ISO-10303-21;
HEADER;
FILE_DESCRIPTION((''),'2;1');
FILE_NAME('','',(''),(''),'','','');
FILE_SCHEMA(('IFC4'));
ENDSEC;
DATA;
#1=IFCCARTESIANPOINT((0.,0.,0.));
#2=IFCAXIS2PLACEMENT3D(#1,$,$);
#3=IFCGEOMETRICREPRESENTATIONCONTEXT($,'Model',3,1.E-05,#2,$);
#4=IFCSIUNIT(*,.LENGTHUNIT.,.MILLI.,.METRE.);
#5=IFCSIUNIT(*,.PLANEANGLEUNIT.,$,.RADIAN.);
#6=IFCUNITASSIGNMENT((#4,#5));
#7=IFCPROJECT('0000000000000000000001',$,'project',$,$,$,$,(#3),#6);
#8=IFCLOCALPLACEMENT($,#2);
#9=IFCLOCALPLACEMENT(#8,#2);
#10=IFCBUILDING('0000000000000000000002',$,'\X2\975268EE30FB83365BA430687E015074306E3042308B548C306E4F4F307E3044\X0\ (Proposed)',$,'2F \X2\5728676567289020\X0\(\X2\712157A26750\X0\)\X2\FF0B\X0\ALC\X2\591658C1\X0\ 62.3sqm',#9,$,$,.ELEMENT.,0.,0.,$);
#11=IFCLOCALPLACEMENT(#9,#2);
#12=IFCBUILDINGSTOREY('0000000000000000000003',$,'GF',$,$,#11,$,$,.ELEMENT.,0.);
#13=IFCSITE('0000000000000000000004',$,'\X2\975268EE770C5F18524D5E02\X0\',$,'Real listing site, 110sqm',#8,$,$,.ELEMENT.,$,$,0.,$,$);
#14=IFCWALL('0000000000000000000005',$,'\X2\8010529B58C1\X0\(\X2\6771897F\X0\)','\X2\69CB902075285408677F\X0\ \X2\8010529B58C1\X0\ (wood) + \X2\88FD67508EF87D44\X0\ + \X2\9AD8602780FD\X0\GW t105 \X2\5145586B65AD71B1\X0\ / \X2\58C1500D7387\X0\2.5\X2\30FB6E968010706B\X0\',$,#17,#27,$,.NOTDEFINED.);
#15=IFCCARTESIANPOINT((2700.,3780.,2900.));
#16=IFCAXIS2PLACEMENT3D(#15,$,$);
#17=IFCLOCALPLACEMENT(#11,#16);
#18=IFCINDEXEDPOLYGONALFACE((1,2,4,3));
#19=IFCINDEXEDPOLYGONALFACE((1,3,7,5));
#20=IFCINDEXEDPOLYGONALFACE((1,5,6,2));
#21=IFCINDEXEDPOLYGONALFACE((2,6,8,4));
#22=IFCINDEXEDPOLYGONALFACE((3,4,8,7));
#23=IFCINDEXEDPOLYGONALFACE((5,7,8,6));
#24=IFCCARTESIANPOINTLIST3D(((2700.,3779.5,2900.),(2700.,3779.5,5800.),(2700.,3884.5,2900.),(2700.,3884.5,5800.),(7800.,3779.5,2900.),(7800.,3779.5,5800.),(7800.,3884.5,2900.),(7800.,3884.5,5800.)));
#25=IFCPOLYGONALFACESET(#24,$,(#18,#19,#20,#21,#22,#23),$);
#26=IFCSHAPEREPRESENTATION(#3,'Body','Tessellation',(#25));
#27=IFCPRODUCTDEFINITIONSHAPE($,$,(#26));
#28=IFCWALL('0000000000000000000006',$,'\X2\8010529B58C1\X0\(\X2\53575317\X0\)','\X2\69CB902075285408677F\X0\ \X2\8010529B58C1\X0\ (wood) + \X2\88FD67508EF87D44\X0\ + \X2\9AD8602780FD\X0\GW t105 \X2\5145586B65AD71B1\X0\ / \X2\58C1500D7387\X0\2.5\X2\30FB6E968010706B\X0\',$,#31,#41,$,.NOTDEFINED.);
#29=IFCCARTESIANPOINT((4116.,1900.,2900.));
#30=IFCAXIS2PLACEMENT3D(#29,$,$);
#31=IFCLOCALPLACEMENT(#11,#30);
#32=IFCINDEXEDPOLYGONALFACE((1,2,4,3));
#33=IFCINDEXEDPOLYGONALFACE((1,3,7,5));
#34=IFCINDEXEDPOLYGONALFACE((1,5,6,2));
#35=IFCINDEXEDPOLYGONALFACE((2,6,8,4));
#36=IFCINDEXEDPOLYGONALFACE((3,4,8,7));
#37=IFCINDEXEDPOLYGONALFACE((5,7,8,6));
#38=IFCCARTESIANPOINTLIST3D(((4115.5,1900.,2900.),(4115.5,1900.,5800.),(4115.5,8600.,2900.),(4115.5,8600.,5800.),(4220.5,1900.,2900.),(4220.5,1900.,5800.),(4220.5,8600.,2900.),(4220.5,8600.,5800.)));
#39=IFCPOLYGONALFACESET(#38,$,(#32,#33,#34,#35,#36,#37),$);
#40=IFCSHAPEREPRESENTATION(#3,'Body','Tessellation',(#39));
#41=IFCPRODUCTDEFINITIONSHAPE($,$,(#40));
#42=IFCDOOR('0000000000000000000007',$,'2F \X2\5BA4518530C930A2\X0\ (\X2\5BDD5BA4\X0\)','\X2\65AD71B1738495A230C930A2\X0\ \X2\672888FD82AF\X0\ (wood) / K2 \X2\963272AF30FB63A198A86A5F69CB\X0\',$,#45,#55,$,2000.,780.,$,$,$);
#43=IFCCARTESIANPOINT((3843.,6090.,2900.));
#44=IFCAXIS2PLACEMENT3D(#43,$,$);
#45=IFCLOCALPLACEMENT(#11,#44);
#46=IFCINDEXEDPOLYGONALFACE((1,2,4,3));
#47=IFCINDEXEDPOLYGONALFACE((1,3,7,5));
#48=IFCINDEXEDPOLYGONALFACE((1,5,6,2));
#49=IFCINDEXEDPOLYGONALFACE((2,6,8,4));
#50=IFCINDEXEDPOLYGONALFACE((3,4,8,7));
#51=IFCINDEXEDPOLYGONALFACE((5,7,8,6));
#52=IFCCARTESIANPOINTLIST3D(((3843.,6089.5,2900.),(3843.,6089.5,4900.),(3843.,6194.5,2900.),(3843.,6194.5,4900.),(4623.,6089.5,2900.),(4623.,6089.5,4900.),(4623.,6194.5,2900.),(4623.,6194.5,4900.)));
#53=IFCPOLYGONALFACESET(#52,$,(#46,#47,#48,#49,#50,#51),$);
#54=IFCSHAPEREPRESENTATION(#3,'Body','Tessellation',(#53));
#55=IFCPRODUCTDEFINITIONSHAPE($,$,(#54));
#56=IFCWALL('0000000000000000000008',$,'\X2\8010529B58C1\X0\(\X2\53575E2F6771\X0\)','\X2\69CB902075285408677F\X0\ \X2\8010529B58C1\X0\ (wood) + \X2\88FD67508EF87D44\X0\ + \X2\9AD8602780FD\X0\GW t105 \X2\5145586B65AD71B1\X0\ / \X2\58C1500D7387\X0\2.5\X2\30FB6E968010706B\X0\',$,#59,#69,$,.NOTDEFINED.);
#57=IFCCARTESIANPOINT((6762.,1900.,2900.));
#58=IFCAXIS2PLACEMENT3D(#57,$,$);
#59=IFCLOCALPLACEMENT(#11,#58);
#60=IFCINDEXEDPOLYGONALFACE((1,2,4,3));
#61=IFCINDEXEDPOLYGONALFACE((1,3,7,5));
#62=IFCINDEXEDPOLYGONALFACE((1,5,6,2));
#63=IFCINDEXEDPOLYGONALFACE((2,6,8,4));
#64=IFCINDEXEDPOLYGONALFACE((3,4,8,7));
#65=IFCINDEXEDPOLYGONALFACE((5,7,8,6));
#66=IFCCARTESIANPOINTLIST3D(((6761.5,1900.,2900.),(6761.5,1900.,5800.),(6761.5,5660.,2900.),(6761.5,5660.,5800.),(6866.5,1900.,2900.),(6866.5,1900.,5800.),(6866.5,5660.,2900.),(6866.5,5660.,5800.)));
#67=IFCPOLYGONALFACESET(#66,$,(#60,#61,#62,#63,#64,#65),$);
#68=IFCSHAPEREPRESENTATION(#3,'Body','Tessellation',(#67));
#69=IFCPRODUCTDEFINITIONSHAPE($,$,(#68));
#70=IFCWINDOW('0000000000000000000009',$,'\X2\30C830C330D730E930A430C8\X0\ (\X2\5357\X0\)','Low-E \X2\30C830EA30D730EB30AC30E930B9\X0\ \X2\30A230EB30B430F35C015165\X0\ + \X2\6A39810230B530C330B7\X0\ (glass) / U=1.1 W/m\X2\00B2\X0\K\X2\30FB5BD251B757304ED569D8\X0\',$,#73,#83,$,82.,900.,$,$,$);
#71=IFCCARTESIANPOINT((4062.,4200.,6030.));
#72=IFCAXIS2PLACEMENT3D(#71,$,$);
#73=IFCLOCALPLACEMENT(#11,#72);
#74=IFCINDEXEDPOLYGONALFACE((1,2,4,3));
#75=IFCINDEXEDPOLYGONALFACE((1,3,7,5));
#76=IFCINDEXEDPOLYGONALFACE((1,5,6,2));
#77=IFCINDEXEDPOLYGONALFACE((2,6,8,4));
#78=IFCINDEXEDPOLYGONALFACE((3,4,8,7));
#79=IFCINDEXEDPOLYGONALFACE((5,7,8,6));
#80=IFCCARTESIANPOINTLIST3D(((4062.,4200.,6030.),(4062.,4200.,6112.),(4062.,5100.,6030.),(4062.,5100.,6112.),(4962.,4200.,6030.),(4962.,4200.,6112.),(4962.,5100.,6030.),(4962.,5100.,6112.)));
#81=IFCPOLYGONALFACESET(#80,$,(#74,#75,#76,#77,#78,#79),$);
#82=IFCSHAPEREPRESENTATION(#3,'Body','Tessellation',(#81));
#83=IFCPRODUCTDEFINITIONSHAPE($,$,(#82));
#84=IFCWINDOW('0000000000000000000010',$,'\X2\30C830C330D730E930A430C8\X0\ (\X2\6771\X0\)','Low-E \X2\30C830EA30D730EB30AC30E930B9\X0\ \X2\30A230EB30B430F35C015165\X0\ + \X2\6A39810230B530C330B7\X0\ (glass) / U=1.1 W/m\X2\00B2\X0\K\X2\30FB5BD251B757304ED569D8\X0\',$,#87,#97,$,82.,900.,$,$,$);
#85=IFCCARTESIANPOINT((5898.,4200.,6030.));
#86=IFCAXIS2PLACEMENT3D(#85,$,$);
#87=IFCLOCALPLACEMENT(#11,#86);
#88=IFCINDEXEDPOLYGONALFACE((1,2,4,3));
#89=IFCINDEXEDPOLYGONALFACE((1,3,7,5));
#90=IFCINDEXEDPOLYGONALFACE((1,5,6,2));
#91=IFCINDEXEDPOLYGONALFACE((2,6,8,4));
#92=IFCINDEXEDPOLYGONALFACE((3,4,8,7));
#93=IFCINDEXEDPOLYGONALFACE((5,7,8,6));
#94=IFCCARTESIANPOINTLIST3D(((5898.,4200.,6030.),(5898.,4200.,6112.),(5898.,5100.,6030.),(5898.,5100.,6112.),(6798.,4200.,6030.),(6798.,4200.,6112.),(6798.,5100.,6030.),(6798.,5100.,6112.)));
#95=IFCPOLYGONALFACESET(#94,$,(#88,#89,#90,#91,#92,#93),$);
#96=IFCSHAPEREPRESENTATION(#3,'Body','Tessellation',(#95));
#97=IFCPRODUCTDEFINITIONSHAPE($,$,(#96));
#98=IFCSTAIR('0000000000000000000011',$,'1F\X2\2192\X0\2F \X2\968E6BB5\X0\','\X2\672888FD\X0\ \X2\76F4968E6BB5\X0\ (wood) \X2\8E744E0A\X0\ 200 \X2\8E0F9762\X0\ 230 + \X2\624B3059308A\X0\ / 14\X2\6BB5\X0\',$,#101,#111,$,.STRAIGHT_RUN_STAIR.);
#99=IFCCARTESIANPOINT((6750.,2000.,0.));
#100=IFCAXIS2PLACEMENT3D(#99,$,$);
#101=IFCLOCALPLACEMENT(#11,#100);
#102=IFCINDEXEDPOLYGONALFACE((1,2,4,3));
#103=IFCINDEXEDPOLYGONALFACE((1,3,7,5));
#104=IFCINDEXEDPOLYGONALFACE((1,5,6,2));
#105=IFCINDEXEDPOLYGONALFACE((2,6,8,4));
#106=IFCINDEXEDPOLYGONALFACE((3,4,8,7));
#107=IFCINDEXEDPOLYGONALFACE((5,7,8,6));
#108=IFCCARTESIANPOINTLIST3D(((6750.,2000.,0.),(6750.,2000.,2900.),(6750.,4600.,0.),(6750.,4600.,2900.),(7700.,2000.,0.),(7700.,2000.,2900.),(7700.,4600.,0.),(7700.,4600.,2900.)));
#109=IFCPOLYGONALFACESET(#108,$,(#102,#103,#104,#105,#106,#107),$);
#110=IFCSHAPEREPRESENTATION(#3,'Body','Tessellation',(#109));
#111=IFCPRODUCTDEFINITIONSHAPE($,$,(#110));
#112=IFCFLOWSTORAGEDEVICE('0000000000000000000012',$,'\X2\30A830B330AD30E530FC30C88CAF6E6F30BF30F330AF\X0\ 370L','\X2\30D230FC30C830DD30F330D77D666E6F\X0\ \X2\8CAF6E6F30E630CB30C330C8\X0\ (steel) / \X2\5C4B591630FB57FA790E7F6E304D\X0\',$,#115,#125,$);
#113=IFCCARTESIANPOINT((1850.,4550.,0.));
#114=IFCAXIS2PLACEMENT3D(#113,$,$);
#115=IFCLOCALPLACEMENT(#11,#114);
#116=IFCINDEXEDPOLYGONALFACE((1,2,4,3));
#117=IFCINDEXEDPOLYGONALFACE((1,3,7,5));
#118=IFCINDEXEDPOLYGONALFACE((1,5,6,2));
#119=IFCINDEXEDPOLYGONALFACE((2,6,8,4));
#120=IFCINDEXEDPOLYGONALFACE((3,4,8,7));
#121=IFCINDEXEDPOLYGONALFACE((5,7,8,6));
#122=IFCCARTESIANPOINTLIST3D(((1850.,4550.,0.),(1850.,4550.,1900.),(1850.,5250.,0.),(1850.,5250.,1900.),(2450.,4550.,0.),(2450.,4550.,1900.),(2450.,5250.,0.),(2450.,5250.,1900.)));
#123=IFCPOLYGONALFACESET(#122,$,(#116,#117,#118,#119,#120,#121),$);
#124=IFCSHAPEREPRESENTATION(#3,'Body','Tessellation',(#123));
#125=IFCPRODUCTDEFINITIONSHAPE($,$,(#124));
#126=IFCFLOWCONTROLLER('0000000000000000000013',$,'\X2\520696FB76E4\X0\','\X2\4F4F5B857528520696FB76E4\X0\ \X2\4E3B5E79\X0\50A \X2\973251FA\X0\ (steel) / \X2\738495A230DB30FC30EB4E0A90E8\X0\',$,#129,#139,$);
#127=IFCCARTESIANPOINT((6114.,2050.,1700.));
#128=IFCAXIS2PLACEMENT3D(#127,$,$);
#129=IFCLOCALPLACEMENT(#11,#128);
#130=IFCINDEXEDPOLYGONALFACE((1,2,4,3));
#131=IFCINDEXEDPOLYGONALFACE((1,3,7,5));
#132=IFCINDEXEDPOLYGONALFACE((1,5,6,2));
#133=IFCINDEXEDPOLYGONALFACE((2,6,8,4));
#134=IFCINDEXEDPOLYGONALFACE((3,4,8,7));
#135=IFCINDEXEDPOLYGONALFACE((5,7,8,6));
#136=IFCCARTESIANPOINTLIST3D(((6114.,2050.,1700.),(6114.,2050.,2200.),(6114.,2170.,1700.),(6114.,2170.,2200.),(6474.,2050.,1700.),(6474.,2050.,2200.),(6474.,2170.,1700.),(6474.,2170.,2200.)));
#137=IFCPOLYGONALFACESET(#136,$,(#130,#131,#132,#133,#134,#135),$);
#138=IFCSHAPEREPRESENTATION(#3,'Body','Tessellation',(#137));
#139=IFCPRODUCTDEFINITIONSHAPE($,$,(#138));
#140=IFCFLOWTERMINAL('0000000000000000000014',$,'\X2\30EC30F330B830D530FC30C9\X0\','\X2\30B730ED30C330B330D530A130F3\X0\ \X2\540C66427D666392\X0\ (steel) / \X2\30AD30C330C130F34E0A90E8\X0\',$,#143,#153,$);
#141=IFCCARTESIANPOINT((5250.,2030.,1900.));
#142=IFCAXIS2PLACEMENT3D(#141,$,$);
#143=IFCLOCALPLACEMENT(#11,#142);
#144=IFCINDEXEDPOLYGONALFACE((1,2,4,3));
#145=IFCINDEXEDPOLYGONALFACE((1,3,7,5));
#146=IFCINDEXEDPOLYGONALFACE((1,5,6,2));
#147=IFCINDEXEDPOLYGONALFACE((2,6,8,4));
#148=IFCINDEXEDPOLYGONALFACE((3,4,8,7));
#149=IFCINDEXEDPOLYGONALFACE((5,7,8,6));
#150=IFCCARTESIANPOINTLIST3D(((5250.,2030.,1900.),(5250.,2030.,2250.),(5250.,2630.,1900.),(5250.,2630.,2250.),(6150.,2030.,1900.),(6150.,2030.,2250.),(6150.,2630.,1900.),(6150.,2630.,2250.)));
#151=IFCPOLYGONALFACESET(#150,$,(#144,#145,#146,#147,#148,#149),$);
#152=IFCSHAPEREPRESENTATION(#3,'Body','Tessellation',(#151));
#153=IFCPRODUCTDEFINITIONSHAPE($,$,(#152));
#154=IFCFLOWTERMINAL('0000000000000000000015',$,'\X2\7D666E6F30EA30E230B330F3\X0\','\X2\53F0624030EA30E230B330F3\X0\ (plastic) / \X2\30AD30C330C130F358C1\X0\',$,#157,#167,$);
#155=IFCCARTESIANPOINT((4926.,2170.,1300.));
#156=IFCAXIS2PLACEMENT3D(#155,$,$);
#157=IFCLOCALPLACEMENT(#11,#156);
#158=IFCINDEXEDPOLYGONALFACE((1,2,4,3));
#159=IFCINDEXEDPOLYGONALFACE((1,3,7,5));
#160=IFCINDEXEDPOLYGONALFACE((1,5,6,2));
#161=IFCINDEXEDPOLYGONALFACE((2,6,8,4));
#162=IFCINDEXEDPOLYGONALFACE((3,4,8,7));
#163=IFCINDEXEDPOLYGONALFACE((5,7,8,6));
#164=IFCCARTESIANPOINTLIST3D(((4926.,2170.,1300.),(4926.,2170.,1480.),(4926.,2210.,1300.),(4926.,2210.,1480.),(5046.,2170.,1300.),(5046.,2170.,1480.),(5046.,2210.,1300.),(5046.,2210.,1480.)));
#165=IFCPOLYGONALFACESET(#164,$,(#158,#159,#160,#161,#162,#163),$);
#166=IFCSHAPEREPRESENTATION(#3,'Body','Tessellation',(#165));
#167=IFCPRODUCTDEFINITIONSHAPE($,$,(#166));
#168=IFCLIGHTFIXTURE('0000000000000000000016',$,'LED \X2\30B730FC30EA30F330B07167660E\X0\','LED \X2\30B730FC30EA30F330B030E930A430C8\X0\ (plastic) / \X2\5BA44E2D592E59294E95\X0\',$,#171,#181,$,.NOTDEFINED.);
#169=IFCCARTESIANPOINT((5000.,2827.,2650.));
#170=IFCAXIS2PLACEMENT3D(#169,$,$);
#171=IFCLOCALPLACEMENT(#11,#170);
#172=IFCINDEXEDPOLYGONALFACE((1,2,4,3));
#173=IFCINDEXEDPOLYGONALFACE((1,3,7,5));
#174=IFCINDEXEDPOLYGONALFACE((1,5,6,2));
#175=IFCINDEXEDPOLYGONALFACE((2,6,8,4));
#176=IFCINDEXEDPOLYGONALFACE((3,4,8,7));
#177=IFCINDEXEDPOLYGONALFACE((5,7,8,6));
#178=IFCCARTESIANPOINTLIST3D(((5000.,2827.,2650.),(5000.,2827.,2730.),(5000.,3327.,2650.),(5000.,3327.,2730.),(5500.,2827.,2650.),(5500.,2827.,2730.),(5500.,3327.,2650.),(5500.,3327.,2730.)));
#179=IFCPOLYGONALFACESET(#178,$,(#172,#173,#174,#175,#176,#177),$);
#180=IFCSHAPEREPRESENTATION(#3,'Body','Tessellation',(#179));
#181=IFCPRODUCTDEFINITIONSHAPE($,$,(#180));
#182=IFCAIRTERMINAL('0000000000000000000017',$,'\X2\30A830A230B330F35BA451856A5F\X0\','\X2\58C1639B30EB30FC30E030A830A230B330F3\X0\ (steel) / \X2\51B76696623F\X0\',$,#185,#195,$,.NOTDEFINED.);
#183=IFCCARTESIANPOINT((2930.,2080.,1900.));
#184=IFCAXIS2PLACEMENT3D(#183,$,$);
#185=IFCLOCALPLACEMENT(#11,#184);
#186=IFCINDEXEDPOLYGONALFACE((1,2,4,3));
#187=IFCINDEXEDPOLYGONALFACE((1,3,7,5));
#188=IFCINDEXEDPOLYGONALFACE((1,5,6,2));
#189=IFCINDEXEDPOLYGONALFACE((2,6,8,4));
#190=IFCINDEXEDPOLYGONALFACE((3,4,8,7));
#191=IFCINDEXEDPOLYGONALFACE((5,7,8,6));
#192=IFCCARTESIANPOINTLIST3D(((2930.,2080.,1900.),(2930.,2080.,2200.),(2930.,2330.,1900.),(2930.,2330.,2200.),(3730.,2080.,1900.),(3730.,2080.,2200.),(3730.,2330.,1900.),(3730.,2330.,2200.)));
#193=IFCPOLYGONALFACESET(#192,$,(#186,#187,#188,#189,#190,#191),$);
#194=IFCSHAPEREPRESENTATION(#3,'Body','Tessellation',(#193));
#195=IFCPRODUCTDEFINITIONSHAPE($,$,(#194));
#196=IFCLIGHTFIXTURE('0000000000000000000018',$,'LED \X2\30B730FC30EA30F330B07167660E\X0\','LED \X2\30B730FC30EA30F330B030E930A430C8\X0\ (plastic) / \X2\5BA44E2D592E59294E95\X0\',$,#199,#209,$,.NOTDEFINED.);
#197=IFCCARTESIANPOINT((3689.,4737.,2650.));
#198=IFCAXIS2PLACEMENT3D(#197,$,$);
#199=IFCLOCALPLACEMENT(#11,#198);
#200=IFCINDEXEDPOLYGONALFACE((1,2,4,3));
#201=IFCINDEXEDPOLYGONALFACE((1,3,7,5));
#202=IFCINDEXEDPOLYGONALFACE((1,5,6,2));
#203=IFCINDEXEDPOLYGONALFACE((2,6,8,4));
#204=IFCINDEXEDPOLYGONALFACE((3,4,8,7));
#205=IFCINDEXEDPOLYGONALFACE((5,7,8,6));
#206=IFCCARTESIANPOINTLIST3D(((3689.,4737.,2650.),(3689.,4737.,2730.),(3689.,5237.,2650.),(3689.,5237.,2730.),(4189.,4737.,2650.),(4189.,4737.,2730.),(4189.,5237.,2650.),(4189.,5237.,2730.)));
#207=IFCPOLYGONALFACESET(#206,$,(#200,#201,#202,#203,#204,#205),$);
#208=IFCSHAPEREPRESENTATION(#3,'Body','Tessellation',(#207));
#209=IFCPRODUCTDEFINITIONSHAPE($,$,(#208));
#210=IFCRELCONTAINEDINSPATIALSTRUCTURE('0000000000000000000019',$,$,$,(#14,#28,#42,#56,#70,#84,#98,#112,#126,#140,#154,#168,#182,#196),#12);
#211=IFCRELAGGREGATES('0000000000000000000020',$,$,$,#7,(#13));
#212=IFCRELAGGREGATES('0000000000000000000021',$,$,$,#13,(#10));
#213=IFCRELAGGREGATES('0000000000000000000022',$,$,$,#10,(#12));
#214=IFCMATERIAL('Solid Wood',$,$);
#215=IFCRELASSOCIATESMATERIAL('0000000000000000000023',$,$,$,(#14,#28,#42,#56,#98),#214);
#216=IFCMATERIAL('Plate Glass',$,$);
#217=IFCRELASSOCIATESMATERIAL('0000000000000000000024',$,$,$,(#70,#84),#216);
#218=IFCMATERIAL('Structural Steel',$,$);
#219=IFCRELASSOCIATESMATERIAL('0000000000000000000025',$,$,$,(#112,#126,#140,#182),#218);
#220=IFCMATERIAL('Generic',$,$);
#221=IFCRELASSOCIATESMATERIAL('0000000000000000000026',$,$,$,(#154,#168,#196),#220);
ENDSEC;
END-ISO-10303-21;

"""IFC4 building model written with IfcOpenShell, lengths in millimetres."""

from ifc_helpers import new_model, si_unit, frame, frame_2d, origin, place, context, project, spatial, rectangle, extrude, material, element, fill, save


model = new_model("IFC4")

# Units and contexts
model_context = context("Model", 3, precision=1e-05, world=origin())
ifc_project = project(units=[si_unit("LENGTHUNIT", "METRE", prefix="MILLI"), si_unit("PLANEANGLEUNIT", "RADIAN")], contexts=[model_context])

# Site, building, storey
site_placement = place(None, origin())
site = spatial("IfcSite", under=ifc_project, at=site_placement, Name="青森県弘前市", ObjectType="Real listing site, 110sqm", CompositionType="ELEMENT", RefElevation=0.0)
building_placement = place(site_placement, origin())
building = spatial("IfcBuilding", under=site, at=building_placement, Name="青森・茶室と縁側のある和の住まい (Proposed)", ObjectType="2F 在来木造(無垢材)＋ALC外壁 62.3sqm", CompositionType="ELEMENT", ElevationOfRefHeight=0.0, ElevationOfTerrain=0.0)
storey_placement = place(building_placement, origin())
storey = spatial("IfcBuildingStorey", under=building, at=storey_placement, Name="GF", CompositionType="ELEMENT", Elevation=0.0)

# Shared definitions
ifc_material_1 = material(Name="Solid Wood")

# Wall
wall_1_placement = place(storey_placement, frame((2700.0, 3780.0, 2900.0)))
element("IfcWall", 1, at=wall_1_placement, inside=storey, material=ifc_material_1, Name="耐力壁(東西)", Description="構造用合板 耐力壁 (wood) + 製材軸組 + 高性能GW t105 充填断熱 / 壁倍率2.5・準耐火", PredefinedType="NOTDEFINED", context=model_context, shape_type="SweptSolid", body=[
    extrude(rectangle(XDim=5100.0, YDim=105.0, at=frame_2d((2550.0, 52.0))), frame((2700.0, 3780.0, 2900.0)), (0.0, 0.0, 1.0), 2900.0),
])

# Wall, opening, door
wall_2_placement = place(storey_placement, frame((4116.0, 1900.0, 2900.0)))
wall_2 = element("IfcWall", 2, at=wall_2_placement, inside=storey, material=ifc_material_1, Name="耐力壁(南北)", Description="構造用合板 耐力壁 (wood) + 製材軸組 + 高性能GW t105 充填断熱 / 壁倍率2.5・準耐火", PredefinedType="NOTDEFINED", context=model_context, shape_type="SweptSolid", body=[
    extrude(rectangle(XDim=105.0, YDim=6700.0, at=frame_2d((52.0, 3350.0))), frame((4116.0, 1900.0, 2900.0)), (0.0, 0.0, 1.0), 2900.0),
])
opening_placement = place(storey_placement, frame((3843.0, 6090.0, 2900.0)))
opening = element("IfcOpeningElement", 3, at=opening_placement, cuts=wall_2, PredefinedType="NOTDEFINED", context=model_context, shape_type="SweptSolid", body=[
    extrude(rectangle(XDim=780.0, YDim=105.0, at=frame_2d((390.0, 52.0))), frame((3843.0, 6090.0, 2900.0)), (0.0, 0.0, 1.0), 2000.0),
])
door_placement = place(storey_placement, frame((3843.0, 6090.0, 2900.0)))
door = element("IfcDoor", 4, at=door_placement, inside=storey, material=ifc_material_1, Name="2F 室内ドア (寝室)", Description="断熱玄関ドア 木製芯 (wood) / K2 防犯・採風機構", OverallHeight=2000.0, OverallWidth=780.0, context=model_context, shape_type="SweptSolid", body=[
    extrude(rectangle(XDim=780.0, YDim=105.0, at=frame_2d((390.0, 52.0))), frame((3843.0, 6090.0, 2900.0)), (0.0, 0.0, 1.0), 2000.0),
])
fill(opening, door)

# Wall
wall_3_placement = place(storey_placement, frame((6762.0, 1900.0, 2900.0)))
element("IfcWall", 5, at=wall_3_placement, inside=storey, material=ifc_material_1, Name="耐力壁(南帯東)", Description="構造用合板 耐力壁 (wood) + 製材軸組 + 高性能GW t105 充填断熱 / 壁倍率2.5・準耐火", PredefinedType="NOTDEFINED", context=model_context, shape_type="SweptSolid", body=[
    extrude(rectangle(XDim=105.0, YDim=3760.0, at=frame_2d((52.0, 1880.0))), frame((6762.0, 1900.0, 2900.0)), (0.0, 0.0, 1.0), 2900.0),
])

# Windows
ifc_material_2 = material(Name="Plate Glass")
window_1_placement = place(storey_placement, frame((4062.0, 4200.0, 6030.0)))
element("IfcWindow", 6, at=window_1_placement, inside=storey, material=ifc_material_2, Name="トップライト (南)", Description="Low-E トリプルガラス アルゴン封入 + 樹脂サッシ (glass) / U=1.1 W/m²K・寒冷地仕様", OverallHeight=82.0, OverallWidth=900.0, context=model_context, shape_type="SweptSolid", body=[
    extrude(rectangle(XDim=900.0, YDim=900.0, at=frame_2d((450.0, 450.0))), frame((4062.0, 4200.0, 6030.0)), (0.0, 0.0, 1.0), 82.0),
])
window_2_placement = place(storey_placement, frame((5898.0, 4200.0, 6030.0)))
element("IfcWindow", 7, at=window_2_placement, inside=storey, material=ifc_material_2, Name="トップライト (東)", Description="Low-E トリプルガラス アルゴン封入 + 樹脂サッシ (glass) / U=1.1 W/m²K・寒冷地仕様", OverallHeight=82.0, OverallWidth=900.0, context=model_context, shape_type="SweptSolid", body=[
    extrude(rectangle(XDim=900.0, YDim=900.0, at=frame_2d((450.0, 450.0))), frame((5898.0, 4200.0, 6030.0)), (0.0, 0.0, 1.0), 82.0),
])

# Stair
stair_placement = place(storey_placement, frame((6750.0, 2000.0, 0.0)))
element("IfcStair", 8, at=stair_placement, inside=storey, material=ifc_material_1, Name="1F→2F 階段", Description="木製 直階段 (wood) 蹴上 200 踏面 230 + 手すり / 14段", PredefinedType="STRAIGHT_RUN_STAIR", context=model_context, shape_type="SweptSolid", body=[
    extrude(rectangle(XDim=950.0, YDim=2600.0, at=frame_2d((475.0, 1300.0))), frame((6750.0, 2000.0, 0.0)), (0.0, 0.0, 1.0), 2900.0),
])

# Flow storage device
ifc_material_3 = material(Name="Structural Steel")
flow_storage_device_placement = place(storey_placement, frame((1850.0, 4550.0, 0.0)))
element("IfcFlowStorageDevice", 9, at=flow_storage_device_placement, inside=storey, material=ifc_material_3, Name="エコキュート貯湯タンク 370L", Description="ヒートポンプ給湯 貯湯ユニット (steel) / 屋外・基礎置き", context=model_context, shape_type="SweptSolid", body=[
    extrude(rectangle(XDim=600.0, YDim=700.0, at=frame_2d((300.0, 350.0))), frame((1850.0, 4550.0, 0.0)), (0.0, 0.0, 1.0), 1900.0),
])

# Flow controller
flow_controller_placement = place(storey_placement, frame((6114.0, 2050.0, 1700.0)))
element("IfcFlowController", 10, at=flow_controller_placement, inside=storey, material=ifc_material_3, Name="分電盤", Description="住宅用分電盤 主幹50A 露出 (steel) / 玄関ホール上部", context=model_context, shape_type="SweptSolid", body=[
    extrude(rectangle(XDim=360.0, YDim=120.0, at=frame_2d((180.0, 60.0))), frame((6114.0, 2050.0, 1700.0)), (0.0, 0.0, 1.0), 500.0),
])

# Flow terminals
flow_terminal_1_placement = place(storey_placement, frame((5250.0, 2030.0, 1900.0)))
element("IfcFlowTerminal", 11, at=flow_terminal_1_placement, inside=storey, material=ifc_material_3, Name="レンジフード", Description="シロッコファン 同時給排 (steel) / キッチン上部", context=model_context, shape_type="SweptSolid", body=[
    extrude(rectangle(XDim=900.0, YDim=600.0, at=frame_2d((450.0, 300.0))), frame((5250.0, 2030.0, 1900.0)), (0.0, 0.0, 1.0), 350.0),
])
ifc_material_4 = material(Name="Generic")
flow_terminal_2_placement = place(storey_placement, frame((4926.0, 2170.0, 1300.0)))
element("IfcFlowTerminal", 12, at=flow_terminal_2_placement, inside=storey, material=ifc_material_4, Name="給湯リモコン", Description="台所リモコン (plastic) / キッチン壁", context=model_context, shape_type="SweptSolid", body=[
    extrude(rectangle(XDim=120.0, YDim=40.0, at=frame_2d((60.0, 20.0))), frame((4926.0, 2170.0, 1300.0)), (0.0, 0.0, 1.0), 180.0),
])

# Light fixture
light_fixture_1_placement = place(storey_placement, frame((5000.0, 2827.0, 2650.0)))
element("IfcLightFixture", 13, at=light_fixture_1_placement, inside=storey, material=ifc_material_4, Name="LED シーリング照明", Description="LED シーリングライト (plastic) / 室中央天井", PredefinedType="NOTDEFINED", context=model_context, shape_type="SweptSolid", body=[
    extrude(rectangle(XDim=500.0, YDim=500.0, at=frame_2d((250.0, 250.0))), frame((5000.0, 2827.0, 2650.0)), (0.0, 0.0, 1.0), 80.0),
])

# Air terminal
air_terminal_1_placement = place(storey_placement, frame((2930.0, 2080.0, 1900.0)))
element("IfcAirTerminal", 14, at=air_terminal_1_placement, inside=storey, material=ifc_material_3, Name="エアコン室内機", Description="壁掛ルームエアコン (steel) / 冷暖房", PredefinedType="NOTDEFINED", context=model_context, shape_type="SweptSolid", body=[
    extrude(rectangle(XDim=800.0, YDim=250.0, at=frame_2d((400.0, 125.0))), frame((2930.0, 2080.0, 1900.0)), (0.0, 0.0, 1.0), 300.0),
])

# Light fixture
light_fixture_2_placement = place(storey_placement, frame((3689.0, 4737.0, 2650.0)))
element("IfcLightFixture", 15, at=light_fixture_2_placement, inside=storey, material=ifc_material_4, Name="LED シーリング照明", Description="LED シーリングライト (plastic) / 室中央天井", PredefinedType="NOTDEFINED", context=model_context, shape_type="SweptSolid", body=[
    extrude(rectangle(XDim=500.0, YDim=500.0, at=frame_2d((250.0, 250.0))), frame((3689.0, 4737.0, 2650.0)), (0.0, 0.0, 1.0), 80.0),
])

save(model, "model.ifc")
